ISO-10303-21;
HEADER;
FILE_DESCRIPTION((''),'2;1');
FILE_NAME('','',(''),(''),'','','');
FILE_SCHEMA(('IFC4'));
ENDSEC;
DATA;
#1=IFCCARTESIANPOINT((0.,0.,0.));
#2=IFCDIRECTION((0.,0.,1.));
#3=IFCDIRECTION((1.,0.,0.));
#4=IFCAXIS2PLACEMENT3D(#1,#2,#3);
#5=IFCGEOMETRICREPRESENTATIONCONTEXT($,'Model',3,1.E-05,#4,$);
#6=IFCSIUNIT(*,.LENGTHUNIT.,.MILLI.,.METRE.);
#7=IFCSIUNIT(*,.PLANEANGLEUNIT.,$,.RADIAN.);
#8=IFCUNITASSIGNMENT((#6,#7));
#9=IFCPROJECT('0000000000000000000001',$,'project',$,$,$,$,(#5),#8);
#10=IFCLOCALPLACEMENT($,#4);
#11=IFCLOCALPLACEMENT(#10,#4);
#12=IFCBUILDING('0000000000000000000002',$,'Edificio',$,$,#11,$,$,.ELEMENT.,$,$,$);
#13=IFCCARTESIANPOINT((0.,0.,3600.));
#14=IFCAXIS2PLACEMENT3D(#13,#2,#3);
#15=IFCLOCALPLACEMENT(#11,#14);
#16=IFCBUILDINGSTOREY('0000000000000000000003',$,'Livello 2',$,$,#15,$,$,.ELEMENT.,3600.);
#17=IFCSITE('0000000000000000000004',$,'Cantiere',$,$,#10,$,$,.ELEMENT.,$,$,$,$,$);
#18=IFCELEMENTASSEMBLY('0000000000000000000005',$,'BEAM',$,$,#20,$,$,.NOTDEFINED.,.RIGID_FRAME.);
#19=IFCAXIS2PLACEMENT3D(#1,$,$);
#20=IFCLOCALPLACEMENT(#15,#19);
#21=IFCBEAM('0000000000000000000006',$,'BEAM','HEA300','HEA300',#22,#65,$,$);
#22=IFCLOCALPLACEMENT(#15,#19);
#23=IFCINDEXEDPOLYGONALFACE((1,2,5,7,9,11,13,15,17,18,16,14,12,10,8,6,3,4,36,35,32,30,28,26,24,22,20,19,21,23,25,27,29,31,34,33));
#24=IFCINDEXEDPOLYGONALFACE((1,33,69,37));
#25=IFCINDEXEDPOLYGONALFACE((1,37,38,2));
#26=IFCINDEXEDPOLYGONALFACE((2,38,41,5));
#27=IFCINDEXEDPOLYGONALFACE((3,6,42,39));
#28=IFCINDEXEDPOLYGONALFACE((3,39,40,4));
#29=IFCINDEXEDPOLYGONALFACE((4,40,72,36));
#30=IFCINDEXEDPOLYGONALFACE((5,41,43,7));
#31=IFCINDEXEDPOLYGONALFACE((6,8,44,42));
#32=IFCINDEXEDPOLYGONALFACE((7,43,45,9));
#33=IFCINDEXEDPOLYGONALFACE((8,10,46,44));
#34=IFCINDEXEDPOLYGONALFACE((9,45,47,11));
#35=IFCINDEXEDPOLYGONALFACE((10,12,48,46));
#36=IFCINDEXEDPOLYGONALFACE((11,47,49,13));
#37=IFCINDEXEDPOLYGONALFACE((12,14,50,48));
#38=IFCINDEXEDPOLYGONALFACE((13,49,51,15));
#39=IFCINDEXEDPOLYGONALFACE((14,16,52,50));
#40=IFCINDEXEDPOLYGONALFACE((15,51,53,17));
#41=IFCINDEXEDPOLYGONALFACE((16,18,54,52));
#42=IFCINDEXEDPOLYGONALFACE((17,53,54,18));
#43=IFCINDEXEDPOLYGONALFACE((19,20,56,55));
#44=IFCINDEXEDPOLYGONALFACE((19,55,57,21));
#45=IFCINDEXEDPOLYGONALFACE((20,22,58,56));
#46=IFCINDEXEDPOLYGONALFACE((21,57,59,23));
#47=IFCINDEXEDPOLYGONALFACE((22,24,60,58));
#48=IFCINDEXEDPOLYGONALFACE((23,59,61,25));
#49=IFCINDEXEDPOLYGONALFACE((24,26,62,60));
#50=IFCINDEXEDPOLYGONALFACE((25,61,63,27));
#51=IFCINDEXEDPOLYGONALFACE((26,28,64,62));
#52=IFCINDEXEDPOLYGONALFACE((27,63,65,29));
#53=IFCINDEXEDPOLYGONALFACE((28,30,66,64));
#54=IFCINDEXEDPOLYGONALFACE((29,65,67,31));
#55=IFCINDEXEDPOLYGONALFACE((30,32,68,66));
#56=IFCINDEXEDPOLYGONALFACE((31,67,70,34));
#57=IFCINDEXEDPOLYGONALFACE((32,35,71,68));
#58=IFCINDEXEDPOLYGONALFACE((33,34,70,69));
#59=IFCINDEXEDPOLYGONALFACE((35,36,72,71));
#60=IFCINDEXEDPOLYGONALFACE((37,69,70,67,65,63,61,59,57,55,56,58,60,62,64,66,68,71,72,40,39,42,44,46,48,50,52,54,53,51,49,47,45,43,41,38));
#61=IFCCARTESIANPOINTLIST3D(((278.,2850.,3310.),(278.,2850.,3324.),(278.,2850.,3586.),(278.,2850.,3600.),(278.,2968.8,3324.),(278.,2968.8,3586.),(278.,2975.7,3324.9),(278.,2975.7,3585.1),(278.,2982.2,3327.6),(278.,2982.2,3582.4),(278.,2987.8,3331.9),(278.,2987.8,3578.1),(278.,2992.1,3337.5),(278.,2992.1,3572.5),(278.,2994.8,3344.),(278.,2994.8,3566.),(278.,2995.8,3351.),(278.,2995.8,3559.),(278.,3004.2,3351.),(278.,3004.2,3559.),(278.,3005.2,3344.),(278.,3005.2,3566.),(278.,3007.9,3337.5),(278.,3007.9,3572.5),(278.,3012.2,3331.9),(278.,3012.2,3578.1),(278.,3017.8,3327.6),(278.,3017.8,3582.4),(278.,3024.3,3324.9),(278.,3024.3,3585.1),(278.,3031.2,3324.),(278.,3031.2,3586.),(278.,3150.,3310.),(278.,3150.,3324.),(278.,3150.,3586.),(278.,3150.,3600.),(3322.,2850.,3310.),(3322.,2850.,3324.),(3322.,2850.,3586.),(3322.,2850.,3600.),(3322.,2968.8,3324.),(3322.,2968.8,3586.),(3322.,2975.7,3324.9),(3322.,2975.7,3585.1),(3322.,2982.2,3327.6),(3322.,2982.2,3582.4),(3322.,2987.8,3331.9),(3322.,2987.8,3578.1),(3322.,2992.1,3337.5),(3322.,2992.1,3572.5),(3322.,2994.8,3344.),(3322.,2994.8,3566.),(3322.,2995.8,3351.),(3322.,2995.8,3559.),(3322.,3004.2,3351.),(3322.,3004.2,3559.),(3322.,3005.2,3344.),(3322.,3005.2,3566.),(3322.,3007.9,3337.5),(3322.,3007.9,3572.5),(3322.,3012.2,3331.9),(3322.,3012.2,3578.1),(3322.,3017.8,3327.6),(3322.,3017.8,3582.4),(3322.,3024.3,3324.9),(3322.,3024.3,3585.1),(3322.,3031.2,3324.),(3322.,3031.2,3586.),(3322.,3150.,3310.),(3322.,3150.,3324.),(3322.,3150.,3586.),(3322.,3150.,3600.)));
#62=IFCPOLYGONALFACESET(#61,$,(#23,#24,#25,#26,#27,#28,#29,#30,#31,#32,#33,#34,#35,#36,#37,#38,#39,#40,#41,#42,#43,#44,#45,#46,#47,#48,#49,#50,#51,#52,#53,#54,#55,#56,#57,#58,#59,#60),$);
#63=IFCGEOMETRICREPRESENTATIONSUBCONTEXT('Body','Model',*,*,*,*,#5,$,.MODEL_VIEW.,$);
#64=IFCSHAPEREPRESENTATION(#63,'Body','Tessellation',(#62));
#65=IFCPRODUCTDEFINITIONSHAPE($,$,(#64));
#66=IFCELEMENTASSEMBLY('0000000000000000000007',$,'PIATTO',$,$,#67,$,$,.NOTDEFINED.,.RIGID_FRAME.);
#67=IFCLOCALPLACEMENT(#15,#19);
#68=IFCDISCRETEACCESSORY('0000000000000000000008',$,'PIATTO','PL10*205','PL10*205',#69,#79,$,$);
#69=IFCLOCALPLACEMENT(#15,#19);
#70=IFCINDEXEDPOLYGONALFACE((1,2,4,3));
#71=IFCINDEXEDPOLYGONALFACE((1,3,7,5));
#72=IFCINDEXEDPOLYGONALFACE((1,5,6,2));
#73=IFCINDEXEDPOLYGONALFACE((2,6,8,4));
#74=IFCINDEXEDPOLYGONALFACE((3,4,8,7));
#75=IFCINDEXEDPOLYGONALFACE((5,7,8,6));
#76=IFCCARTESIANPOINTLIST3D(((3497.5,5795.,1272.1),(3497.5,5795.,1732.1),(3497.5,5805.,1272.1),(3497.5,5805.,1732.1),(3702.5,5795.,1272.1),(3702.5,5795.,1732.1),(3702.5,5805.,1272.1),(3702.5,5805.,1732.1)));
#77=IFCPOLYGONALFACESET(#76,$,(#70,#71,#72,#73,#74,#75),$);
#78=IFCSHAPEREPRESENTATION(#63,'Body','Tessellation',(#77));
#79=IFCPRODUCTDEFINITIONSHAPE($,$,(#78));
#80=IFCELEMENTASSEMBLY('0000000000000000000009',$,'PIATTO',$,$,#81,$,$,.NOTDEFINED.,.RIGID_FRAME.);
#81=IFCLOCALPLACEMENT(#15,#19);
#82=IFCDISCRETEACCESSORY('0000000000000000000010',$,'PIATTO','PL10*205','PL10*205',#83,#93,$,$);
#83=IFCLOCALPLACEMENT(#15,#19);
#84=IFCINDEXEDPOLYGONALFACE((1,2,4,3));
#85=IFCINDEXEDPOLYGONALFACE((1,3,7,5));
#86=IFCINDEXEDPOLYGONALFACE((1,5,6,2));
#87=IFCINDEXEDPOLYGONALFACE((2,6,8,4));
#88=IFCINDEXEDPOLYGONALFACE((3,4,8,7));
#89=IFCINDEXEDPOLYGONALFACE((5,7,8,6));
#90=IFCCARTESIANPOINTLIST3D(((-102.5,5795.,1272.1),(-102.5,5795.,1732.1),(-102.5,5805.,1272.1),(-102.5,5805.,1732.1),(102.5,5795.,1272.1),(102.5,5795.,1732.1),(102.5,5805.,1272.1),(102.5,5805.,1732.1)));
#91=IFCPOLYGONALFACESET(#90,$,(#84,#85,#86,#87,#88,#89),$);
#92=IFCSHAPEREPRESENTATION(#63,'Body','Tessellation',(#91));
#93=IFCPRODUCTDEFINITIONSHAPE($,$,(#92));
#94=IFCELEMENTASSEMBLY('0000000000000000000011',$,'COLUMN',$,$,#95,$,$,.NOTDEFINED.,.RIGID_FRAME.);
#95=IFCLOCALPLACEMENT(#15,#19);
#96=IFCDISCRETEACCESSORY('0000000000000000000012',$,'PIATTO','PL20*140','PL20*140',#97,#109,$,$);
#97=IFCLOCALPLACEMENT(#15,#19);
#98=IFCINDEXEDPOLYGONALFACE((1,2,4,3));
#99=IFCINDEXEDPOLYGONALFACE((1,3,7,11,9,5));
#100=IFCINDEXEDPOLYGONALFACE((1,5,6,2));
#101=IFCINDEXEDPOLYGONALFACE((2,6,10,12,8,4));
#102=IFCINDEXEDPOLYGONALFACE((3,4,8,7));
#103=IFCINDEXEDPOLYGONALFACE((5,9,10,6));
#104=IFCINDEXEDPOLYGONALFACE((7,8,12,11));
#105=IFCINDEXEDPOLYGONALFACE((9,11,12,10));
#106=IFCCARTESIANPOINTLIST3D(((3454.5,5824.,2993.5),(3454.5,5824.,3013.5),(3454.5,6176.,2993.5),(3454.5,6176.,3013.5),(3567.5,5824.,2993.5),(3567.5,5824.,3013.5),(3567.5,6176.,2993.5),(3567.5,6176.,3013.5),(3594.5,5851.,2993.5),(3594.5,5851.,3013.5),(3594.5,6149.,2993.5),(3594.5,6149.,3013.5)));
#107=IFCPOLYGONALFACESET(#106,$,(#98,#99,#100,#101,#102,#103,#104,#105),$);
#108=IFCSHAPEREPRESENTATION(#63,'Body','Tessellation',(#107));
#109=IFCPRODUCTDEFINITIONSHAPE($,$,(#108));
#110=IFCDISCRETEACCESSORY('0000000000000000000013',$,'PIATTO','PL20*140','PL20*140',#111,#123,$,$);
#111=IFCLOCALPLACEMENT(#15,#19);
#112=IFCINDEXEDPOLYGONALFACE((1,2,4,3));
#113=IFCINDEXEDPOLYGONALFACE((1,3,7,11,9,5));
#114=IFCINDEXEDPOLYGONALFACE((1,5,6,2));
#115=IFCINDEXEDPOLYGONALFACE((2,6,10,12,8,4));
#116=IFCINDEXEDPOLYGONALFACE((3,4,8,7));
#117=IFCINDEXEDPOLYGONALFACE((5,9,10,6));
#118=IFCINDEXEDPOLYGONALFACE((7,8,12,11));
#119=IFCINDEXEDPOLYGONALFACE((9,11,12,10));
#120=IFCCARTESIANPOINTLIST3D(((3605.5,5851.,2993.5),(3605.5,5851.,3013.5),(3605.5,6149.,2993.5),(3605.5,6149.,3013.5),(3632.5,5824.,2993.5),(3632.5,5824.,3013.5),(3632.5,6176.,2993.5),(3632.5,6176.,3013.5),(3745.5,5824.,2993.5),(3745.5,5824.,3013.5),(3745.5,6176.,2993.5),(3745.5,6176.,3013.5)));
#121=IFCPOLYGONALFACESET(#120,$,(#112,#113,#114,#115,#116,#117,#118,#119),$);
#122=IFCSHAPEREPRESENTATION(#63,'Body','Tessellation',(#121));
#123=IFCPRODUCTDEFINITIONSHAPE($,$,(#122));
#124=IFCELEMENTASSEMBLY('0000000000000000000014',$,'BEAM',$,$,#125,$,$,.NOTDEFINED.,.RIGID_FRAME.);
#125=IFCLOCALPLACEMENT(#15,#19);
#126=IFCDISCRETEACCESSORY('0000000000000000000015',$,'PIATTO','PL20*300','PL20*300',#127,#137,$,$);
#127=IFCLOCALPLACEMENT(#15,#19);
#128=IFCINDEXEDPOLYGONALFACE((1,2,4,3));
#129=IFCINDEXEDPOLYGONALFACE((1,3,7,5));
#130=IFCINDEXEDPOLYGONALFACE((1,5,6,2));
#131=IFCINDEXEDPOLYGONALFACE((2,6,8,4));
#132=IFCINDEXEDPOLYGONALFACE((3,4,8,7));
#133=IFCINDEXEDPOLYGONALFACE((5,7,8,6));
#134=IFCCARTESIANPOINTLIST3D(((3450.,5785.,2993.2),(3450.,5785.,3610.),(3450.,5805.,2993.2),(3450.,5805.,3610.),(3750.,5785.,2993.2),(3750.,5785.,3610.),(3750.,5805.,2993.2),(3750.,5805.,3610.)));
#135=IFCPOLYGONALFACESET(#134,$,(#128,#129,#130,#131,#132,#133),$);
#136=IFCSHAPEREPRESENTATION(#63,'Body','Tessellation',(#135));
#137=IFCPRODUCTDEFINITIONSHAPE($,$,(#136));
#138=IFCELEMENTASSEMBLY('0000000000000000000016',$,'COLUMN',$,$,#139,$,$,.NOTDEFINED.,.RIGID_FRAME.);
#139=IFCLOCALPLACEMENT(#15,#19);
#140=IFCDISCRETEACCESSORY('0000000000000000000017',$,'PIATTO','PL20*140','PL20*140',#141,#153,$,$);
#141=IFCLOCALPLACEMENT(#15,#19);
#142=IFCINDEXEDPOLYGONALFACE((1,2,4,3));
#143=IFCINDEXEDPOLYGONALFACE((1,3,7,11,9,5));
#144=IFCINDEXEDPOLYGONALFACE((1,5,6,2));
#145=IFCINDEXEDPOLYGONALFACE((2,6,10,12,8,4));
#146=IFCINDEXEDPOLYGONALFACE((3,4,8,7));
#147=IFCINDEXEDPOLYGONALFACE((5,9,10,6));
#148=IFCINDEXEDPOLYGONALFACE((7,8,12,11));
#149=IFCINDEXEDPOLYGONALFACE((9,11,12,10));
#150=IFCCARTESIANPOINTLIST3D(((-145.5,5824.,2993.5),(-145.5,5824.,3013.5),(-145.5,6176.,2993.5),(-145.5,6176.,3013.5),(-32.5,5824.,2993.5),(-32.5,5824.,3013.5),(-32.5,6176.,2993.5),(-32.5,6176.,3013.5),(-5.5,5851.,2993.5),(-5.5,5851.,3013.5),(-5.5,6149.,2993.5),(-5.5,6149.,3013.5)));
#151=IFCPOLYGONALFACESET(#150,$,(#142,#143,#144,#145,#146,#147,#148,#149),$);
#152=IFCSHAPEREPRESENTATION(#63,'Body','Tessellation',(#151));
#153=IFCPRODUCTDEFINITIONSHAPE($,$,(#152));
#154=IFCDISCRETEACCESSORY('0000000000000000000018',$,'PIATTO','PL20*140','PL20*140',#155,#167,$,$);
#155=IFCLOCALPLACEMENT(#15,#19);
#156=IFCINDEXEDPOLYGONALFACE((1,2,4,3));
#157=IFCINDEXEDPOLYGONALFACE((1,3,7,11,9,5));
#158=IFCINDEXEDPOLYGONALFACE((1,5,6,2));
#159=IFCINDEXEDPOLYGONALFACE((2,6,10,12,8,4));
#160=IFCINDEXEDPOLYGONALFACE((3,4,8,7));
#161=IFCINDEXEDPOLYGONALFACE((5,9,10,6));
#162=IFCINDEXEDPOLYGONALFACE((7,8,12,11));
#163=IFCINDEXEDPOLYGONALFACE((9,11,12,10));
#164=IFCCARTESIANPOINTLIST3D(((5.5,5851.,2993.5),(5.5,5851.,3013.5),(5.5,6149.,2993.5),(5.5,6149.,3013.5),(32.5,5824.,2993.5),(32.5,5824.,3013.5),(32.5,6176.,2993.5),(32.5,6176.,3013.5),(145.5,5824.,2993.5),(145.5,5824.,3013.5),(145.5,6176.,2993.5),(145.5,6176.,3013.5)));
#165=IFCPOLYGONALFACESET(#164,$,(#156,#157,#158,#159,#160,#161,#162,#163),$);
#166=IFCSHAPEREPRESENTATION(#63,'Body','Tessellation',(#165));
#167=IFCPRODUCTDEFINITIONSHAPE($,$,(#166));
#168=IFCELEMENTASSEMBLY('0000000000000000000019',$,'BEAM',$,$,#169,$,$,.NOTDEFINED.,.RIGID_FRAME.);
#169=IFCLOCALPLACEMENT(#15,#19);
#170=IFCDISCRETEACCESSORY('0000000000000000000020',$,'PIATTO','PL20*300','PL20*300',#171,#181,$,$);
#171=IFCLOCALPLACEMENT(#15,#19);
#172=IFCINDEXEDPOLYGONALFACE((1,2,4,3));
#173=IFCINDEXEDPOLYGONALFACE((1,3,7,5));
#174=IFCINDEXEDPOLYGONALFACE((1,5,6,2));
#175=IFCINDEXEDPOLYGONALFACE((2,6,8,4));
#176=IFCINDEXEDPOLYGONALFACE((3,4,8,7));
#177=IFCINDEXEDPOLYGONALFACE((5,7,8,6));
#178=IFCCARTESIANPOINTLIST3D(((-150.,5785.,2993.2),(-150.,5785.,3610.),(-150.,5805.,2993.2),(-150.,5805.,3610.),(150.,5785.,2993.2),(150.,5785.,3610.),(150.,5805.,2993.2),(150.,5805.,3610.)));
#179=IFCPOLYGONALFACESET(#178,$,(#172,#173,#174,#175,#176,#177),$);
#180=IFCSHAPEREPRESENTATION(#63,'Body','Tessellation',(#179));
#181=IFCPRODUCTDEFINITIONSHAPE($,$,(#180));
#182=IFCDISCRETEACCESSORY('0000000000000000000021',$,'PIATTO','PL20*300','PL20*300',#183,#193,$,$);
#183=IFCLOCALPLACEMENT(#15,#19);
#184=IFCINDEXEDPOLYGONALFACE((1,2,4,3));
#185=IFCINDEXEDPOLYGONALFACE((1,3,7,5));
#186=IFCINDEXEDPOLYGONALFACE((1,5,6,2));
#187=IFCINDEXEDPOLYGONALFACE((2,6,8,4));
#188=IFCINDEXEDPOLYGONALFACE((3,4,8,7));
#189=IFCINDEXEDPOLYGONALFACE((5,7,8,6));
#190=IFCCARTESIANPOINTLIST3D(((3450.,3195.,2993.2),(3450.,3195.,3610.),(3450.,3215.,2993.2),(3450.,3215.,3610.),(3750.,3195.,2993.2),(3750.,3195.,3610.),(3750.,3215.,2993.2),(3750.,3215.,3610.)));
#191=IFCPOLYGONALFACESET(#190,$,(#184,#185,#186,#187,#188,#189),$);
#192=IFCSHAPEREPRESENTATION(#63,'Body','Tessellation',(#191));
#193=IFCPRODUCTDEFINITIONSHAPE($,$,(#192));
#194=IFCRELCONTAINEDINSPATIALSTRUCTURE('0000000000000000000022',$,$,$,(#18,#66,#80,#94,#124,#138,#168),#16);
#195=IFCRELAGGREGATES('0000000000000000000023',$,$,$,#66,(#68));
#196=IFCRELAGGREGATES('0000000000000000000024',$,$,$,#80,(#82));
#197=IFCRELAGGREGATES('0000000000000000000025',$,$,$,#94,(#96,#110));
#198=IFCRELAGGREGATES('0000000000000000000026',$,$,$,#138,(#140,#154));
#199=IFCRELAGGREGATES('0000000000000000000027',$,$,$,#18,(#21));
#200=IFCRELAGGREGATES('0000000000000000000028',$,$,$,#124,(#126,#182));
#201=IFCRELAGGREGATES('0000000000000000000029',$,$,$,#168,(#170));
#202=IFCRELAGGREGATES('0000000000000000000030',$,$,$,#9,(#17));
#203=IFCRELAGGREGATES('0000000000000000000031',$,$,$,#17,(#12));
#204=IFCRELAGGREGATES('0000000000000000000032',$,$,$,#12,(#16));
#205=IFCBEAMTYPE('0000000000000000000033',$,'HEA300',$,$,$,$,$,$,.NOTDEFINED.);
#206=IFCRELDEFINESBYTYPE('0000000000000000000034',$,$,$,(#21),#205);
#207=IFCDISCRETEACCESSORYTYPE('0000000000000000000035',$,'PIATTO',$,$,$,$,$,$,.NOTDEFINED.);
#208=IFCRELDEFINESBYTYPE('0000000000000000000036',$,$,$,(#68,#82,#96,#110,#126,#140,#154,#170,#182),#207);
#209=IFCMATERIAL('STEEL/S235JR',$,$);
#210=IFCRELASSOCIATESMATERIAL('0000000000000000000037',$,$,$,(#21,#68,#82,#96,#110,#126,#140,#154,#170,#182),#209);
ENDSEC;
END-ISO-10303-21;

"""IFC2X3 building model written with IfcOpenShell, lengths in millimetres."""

from ifc_helpers import new_model, si_unit, frame, origin_with_axes, origin_2d_with_axis, place, context, subcontext, project, spatial, polyline, i_section, outline, extrude, clip, halfspace, material, type_object, element, aggregate, save


model = new_model("IFC2X3")

# Units and contexts
model_context = context("Model", 3, precision=1e-05, world=origin_with_axes())
body_context = subcontext(model_context, "Body", "Model", "MODEL_VIEW")
ifc_project = project(units=[si_unit("LENGTHUNIT", "METRE", prefix="MILLI"), si_unit("PLANEANGLEUNIT", "RADIAN")], contexts=[model_context])

# Site, building, storey
site_placement = place(None, origin_with_axes())
site = spatial("IfcSite", under=ifc_project, at=site_placement, Name="Cantiere", CompositionType="ELEMENT")
building_placement = place(site_placement, origin_with_axes())
building = spatial("IfcBuilding", under=site, at=building_placement, Name="Edificio", CompositionType="ELEMENT")
storey_placement = place(building_placement, frame((0.0, 0.0, 3600.0), z_axis=(0.0, 0.0, 1.0), x_axis=(1.0, 0.0, 0.0)))
storey = spatial("IfcBuildingStorey", under=building, at=storey_placement, Name="Livello 2", CompositionType="ELEMENT", Elevation=3600.0)

# Element assembly, beam
assembly_1_placement = place(storey_placement, origin_with_axes())
assembly_1 = element("IfcElementAssembly", 1, at=assembly_1_placement, inside=storey, Name="BEAM", AssemblyPlace="NOTDEFINED", PredefinedType="RIGID_FRAME")
ifc_material_1 = material(Name="STEEL/S235JR")
beam_type = type_object("IfcBeamType", Name="HEA300", PredefinedType="NOTDEFINED")
beam_placement = place(assembly_1_placement, frame((0.0, 3000.0, 3455.0), z_axis=(0.0, 0.0, 1.0), x_axis=(1.0, 0.0, 0.0)))
beam = element("IfcBeam", 2, at=beam_placement, type_object=beam_type, material=ifc_material_1, Name="BEAM", Description="HEA300", ObjectType="HEA300", context=body_context, shape_type="Clipping", body=[
    clip(clip(extrude(i_section(OverallWidth=300.0, OverallDepth=290.0, WebThickness=8.5, FlangeThickness=14.0, FilletRadius=27.0, at=origin_2d_with_axis()), frame((3322.0, 0.0, 0.0), z_axis=(-1.0, 0.0, 0.0), x_axis=(0.0, -1.0, 0.0)), (0.0, 0.0, 1.0), 3044.0), halfspace(frame((3322.0, -150.0, 0.0), z_axis=(1.0, 0.0, 0.0), x_axis=(0.0, 0.0, 1.0)), False)), halfspace(frame((278.0, 150.0, 0.0), z_axis=(-1.0, 0.0, 0.0), x_axis=(0.0, 0.0, 1.0)), False)),
])

# Element assemblies, discrete accessories
assembly_2_placement = place(storey_placement, origin_with_axes())
assembly_2 = element("IfcElementAssembly", 3, at=assembly_2_placement, inside=storey, Name="PIATTO", AssemblyPlace="NOTDEFINED", PredefinedType="RIGID_FRAME")
discrete_accessory_type_1 = type_object("IfcDiscreteAccessoryType", Name="PIATTO")
discrete_accessory_1_placement = place(assembly_2_placement, frame((3600.0, 5800.0, 1272.1), z_axis=(0.0, -1.0, 0.0), x_axis=(0.0, 0.0, 1.0)))
discrete_accessory_1 = element("IfcDiscreteAccessory", 4, at=discrete_accessory_1_placement, type_object=discrete_accessory_type_1, material=ifc_material_1, Name="PIATTO", Description="PL10*205", ObjectType="PL10*205", context=body_context, shape_type="SweptSolid", body=[
    extrude(outline(polyline([(0.0, 102.5), (460.0, 102.5), (460.0, -102.5), (0.0, -102.5), (0.0, 102.5)])), frame((0.0, 0.0, -5.0), z_axis=(0.0, 0.0, 1.0), x_axis=(1.0, 0.0, 0.0)), (0.0, 0.0, 1.0), 10.0),
])
aggregate(assembly_2, [discrete_accessory_1])
assembly_3_placement = place(storey_placement, origin_with_axes())
assembly_3 = element("IfcElementAssembly", 5, at=assembly_3_placement, inside=storey, Name="PIATTO", AssemblyPlace="NOTDEFINED", PredefinedType="RIGID_FRAME")
discrete_accessory_2_placement = place(assembly_3_placement, frame((0.0, 5800.0, 1272.1), z_axis=(0.0, -1.0, 0.0), x_axis=(0.0, 0.0, 1.0)))
discrete_accessory_2 = element("IfcDiscreteAccessory", 6, at=discrete_accessory_2_placement, type_object=discrete_accessory_type_1, material=ifc_material_1, Name="PIATTO", Description="PL10*205", ObjectType="PL10*205", context=body_context, shape_type="SweptSolid", body=[
    extrude(outline(polyline([(0.0, 102.5), (460.0, 102.5), (460.0, -102.5), (0.0, -102.5), (0.0, 102.5)])), frame((0.0, 0.0, -5.0), z_axis=(0.0, 0.0, 1.0), x_axis=(1.0, 0.0, 0.0)), (0.0, 0.0, 1.0), 10.0),
])
aggregate(assembly_3, [discrete_accessory_2])

# Element assembly, discrete accessories
assembly_4_placement = place(storey_placement, origin_with_axes())
assembly_4 = element("IfcElementAssembly", 7, at=assembly_4_placement, inside=storey, Name="COLUMN", AssemblyPlace="NOTDEFINED", PredefinedType="RIGID_FRAME")
discrete_accessory_3_placement = place(assembly_4_placement, frame((3454.5, 5824.0, 3003.5), z_axis=(0.0, 0.0, 1.0), x_axis=(1.0, 0.0, 0.0)))
discrete_accessory_3 = element("IfcDiscreteAccessory", 8, at=discrete_accessory_3_placement, type_object=discrete_accessory_type_1, material=ifc_material_1, Name="PIATTO", Description="PL20*140", ObjectType="PL20*140", context=body_context, shape_type="SweptSolid", body=[
    extrude(outline(polyline([(0.0, 0.0), (113.0, 0.0), (140.0, 27.0), (140.0, 325.0), (113.0, 352.0), (0.0, 352.0), (0.0, 0.0)])), frame((0.0, 0.0, -10.0), z_axis=(0.0, 0.0, 1.0), x_axis=(1.0, 0.0, 0.0)), (0.0, 0.0, 1.0), 20.0),
])
discrete_accessory_4_placement = place(assembly_4_placement, frame((3745.5, 5824.0, 3003.5), z_axis=(0.0, 0.0, -1.0), x_axis=(-1.0, 0.0, 0.0)))
discrete_accessory_4 = element("IfcDiscreteAccessory", 9, at=discrete_accessory_4_placement, type_object=discrete_accessory_type_1, material=ifc_material_1, Name="PIATTO", Description="PL20*140", ObjectType="PL20*140", context=body_context, shape_type="SweptSolid", body=[
    extrude(outline(polyline([(0.0, 0.0), (113.0, 0.0), (140.0, 27.0), (140.0, 325.0), (113.0, 352.0), (0.0, 352.0), (0.0, 0.0)])), frame((0.0, 0.0, -10.0), z_axis=(0.0, 0.0, 1.0), x_axis=(1.0, 0.0, 0.0)), (0.0, 0.0, 1.0), 20.0),
])
aggregate(assembly_4, [discrete_accessory_3, discrete_accessory_4])

# Element assembly, discrete accessory
assembly_5_placement = place(storey_placement, origin_with_axes())
assembly_5 = element("IfcElementAssembly", 10, at=assembly_5_placement, inside=storey, Name="BEAM", AssemblyPlace="NOTDEFINED", PredefinedType="RIGID_FRAME")
discrete_accessory_5_placement = place(assembly_5_placement, frame((3600.0, 5795.0, 2993.2), z_axis=(0.0, -1.0, 0.0), x_axis=(0.0, 0.0, 1.0)))
discrete_accessory_5 = element("IfcDiscreteAccessory", 11, at=discrete_accessory_5_placement, type_object=discrete_accessory_type_1, material=ifc_material_1, Name="PIATTO", Description="PL20*300", ObjectType="PL20*300", context=body_context, shape_type="SweptSolid", body=[
    extrude(outline(polyline([(0.0, 150.0), (616.8, 150.0), (616.8, -150.0), (0.0, -150.0), (0.0, 150.0)])), frame((0.0, 0.0, -10.0), z_axis=(0.0, 0.0, 1.0), x_axis=(1.0, 0.0, 0.0)), (0.0, 0.0, 1.0), 20.0),
])

# Element assembly, discrete accessories
assembly_6_placement = place(storey_placement, origin_with_axes())
assembly_6 = element("IfcElementAssembly", 12, at=assembly_6_placement, inside=storey, Name="COLUMN", AssemblyPlace="NOTDEFINED", PredefinedType="RIGID_FRAME")
discrete_accessory_6_placement = place(assembly_6_placement, frame((-145.5, 5824.0, 3003.5), z_axis=(0.0, 0.0, 1.0), x_axis=(1.0, 0.0, 0.0)))
discrete_accessory_6 = element("IfcDiscreteAccessory", 13, at=discrete_accessory_6_placement, type_object=discrete_accessory_type_1, material=ifc_material_1, Name="PIATTO", Description="PL20*140", ObjectType="PL20*140", context=body_context, shape_type="SweptSolid", body=[
    extrude(outline(polyline([(0.0, 0.0), (113.0, 0.0), (140.0, 27.0), (140.0, 325.0), (113.0, 352.0), (0.0, 352.0), (0.0, 0.0)])), frame((0.0, 0.0, -10.0), z_axis=(0.0, 0.0, 1.0), x_axis=(1.0, 0.0, 0.0)), (0.0, 0.0, 1.0), 20.0),
])
discrete_accessory_7_placement = place(assembly_6_placement, frame((145.5, 5824.0, 3003.5), z_axis=(0.0, 0.0, -1.0), x_axis=(-1.0, 0.0, 0.0)))
discrete_accessory_7 = element("IfcDiscreteAccessory", 14, at=discrete_accessory_7_placement, type_object=discrete_accessory_type_1, material=ifc_material_1, Name="PIATTO", Description="PL20*140", ObjectType="PL20*140", context=body_context, shape_type="SweptSolid", body=[
    extrude(outline(polyline([(0.0, 0.0), (113.0, 0.0), (140.0, 27.0), (140.0, 325.0), (113.0, 352.0), (0.0, 352.0), (0.0, 0.0)])), frame((0.0, 0.0, -10.0), z_axis=(0.0, 0.0, 1.0), x_axis=(1.0, 0.0, 0.0)), (0.0, 0.0, 1.0), 20.0),
])
aggregate(assembly_6, [discrete_accessory_6, discrete_accessory_7])

# Element assembly, discrete accessory
assembly_7_placement = place(storey_placement, origin_with_axes())
assembly_7 = element("IfcElementAssembly", 15, at=assembly_7_placement, inside=storey, Name="BEAM", AssemblyPlace="NOTDEFINED", PredefinedType="RIGID_FRAME")
discrete_accessory_8_placement = place(assembly_7_placement, frame((0.0, 5795.0, 2993.2), z_axis=(0.0, -1.0, 0.0), x_axis=(0.0, 0.0, 1.0)))
discrete_accessory_8 = element("IfcDiscreteAccessory", 16, at=discrete_accessory_8_placement, type_object=discrete_accessory_type_1, material=ifc_material_1, Name="PIATTO", Description="PL20*300", ObjectType="PL20*300", context=body_context, shape_type="SweptSolid", body=[
    extrude(outline(polyline([(0.0, 150.0), (616.8, 150.0), (616.8, -150.0), (0.0, -150.0), (0.0, 150.0)])), frame((0.0, 0.0, -10.0), z_axis=(0.0, 0.0, 1.0), x_axis=(1.0, 0.0, 0.0)), (0.0, 0.0, 1.0), 20.0),
])

# Discrete accessory
discrete_accessory_9_placement = place(assembly_5_placement, frame((3600.0, 3205.0, 2993.2), z_axis=(0.0, 1.0, 0.0), x_axis=(0.0, 0.0, 1.0)))
discrete_accessory_9 = element("IfcDiscreteAccessory", 17, at=discrete_accessory_9_placement, type_object=discrete_accessory_type_1, material=ifc_material_1, Name="PIATTO", Description="PL20*300", ObjectType="PL20*300", context=body_context, shape_type="SweptSolid", body=[
    extrude(outline(polyline([(0.0, -150.0), (0.0, 150.0), (616.8, 150.0), (616.8, -150.0), (0.0, -150.0)])), frame((0.0, 0.0, -10.0), z_axis=(0.0, 0.0, 1.0), x_axis=(1.0, 0.0, 0.0)), (0.0, 0.0, 1.0), 20.0),
])

aggregate(assembly_1, [beam])

aggregate(assembly_5, [discrete_accessory_5, discrete_accessory_9])
aggregate(assembly_7, [discrete_accessory_8])

save(model, "model.ifc")
